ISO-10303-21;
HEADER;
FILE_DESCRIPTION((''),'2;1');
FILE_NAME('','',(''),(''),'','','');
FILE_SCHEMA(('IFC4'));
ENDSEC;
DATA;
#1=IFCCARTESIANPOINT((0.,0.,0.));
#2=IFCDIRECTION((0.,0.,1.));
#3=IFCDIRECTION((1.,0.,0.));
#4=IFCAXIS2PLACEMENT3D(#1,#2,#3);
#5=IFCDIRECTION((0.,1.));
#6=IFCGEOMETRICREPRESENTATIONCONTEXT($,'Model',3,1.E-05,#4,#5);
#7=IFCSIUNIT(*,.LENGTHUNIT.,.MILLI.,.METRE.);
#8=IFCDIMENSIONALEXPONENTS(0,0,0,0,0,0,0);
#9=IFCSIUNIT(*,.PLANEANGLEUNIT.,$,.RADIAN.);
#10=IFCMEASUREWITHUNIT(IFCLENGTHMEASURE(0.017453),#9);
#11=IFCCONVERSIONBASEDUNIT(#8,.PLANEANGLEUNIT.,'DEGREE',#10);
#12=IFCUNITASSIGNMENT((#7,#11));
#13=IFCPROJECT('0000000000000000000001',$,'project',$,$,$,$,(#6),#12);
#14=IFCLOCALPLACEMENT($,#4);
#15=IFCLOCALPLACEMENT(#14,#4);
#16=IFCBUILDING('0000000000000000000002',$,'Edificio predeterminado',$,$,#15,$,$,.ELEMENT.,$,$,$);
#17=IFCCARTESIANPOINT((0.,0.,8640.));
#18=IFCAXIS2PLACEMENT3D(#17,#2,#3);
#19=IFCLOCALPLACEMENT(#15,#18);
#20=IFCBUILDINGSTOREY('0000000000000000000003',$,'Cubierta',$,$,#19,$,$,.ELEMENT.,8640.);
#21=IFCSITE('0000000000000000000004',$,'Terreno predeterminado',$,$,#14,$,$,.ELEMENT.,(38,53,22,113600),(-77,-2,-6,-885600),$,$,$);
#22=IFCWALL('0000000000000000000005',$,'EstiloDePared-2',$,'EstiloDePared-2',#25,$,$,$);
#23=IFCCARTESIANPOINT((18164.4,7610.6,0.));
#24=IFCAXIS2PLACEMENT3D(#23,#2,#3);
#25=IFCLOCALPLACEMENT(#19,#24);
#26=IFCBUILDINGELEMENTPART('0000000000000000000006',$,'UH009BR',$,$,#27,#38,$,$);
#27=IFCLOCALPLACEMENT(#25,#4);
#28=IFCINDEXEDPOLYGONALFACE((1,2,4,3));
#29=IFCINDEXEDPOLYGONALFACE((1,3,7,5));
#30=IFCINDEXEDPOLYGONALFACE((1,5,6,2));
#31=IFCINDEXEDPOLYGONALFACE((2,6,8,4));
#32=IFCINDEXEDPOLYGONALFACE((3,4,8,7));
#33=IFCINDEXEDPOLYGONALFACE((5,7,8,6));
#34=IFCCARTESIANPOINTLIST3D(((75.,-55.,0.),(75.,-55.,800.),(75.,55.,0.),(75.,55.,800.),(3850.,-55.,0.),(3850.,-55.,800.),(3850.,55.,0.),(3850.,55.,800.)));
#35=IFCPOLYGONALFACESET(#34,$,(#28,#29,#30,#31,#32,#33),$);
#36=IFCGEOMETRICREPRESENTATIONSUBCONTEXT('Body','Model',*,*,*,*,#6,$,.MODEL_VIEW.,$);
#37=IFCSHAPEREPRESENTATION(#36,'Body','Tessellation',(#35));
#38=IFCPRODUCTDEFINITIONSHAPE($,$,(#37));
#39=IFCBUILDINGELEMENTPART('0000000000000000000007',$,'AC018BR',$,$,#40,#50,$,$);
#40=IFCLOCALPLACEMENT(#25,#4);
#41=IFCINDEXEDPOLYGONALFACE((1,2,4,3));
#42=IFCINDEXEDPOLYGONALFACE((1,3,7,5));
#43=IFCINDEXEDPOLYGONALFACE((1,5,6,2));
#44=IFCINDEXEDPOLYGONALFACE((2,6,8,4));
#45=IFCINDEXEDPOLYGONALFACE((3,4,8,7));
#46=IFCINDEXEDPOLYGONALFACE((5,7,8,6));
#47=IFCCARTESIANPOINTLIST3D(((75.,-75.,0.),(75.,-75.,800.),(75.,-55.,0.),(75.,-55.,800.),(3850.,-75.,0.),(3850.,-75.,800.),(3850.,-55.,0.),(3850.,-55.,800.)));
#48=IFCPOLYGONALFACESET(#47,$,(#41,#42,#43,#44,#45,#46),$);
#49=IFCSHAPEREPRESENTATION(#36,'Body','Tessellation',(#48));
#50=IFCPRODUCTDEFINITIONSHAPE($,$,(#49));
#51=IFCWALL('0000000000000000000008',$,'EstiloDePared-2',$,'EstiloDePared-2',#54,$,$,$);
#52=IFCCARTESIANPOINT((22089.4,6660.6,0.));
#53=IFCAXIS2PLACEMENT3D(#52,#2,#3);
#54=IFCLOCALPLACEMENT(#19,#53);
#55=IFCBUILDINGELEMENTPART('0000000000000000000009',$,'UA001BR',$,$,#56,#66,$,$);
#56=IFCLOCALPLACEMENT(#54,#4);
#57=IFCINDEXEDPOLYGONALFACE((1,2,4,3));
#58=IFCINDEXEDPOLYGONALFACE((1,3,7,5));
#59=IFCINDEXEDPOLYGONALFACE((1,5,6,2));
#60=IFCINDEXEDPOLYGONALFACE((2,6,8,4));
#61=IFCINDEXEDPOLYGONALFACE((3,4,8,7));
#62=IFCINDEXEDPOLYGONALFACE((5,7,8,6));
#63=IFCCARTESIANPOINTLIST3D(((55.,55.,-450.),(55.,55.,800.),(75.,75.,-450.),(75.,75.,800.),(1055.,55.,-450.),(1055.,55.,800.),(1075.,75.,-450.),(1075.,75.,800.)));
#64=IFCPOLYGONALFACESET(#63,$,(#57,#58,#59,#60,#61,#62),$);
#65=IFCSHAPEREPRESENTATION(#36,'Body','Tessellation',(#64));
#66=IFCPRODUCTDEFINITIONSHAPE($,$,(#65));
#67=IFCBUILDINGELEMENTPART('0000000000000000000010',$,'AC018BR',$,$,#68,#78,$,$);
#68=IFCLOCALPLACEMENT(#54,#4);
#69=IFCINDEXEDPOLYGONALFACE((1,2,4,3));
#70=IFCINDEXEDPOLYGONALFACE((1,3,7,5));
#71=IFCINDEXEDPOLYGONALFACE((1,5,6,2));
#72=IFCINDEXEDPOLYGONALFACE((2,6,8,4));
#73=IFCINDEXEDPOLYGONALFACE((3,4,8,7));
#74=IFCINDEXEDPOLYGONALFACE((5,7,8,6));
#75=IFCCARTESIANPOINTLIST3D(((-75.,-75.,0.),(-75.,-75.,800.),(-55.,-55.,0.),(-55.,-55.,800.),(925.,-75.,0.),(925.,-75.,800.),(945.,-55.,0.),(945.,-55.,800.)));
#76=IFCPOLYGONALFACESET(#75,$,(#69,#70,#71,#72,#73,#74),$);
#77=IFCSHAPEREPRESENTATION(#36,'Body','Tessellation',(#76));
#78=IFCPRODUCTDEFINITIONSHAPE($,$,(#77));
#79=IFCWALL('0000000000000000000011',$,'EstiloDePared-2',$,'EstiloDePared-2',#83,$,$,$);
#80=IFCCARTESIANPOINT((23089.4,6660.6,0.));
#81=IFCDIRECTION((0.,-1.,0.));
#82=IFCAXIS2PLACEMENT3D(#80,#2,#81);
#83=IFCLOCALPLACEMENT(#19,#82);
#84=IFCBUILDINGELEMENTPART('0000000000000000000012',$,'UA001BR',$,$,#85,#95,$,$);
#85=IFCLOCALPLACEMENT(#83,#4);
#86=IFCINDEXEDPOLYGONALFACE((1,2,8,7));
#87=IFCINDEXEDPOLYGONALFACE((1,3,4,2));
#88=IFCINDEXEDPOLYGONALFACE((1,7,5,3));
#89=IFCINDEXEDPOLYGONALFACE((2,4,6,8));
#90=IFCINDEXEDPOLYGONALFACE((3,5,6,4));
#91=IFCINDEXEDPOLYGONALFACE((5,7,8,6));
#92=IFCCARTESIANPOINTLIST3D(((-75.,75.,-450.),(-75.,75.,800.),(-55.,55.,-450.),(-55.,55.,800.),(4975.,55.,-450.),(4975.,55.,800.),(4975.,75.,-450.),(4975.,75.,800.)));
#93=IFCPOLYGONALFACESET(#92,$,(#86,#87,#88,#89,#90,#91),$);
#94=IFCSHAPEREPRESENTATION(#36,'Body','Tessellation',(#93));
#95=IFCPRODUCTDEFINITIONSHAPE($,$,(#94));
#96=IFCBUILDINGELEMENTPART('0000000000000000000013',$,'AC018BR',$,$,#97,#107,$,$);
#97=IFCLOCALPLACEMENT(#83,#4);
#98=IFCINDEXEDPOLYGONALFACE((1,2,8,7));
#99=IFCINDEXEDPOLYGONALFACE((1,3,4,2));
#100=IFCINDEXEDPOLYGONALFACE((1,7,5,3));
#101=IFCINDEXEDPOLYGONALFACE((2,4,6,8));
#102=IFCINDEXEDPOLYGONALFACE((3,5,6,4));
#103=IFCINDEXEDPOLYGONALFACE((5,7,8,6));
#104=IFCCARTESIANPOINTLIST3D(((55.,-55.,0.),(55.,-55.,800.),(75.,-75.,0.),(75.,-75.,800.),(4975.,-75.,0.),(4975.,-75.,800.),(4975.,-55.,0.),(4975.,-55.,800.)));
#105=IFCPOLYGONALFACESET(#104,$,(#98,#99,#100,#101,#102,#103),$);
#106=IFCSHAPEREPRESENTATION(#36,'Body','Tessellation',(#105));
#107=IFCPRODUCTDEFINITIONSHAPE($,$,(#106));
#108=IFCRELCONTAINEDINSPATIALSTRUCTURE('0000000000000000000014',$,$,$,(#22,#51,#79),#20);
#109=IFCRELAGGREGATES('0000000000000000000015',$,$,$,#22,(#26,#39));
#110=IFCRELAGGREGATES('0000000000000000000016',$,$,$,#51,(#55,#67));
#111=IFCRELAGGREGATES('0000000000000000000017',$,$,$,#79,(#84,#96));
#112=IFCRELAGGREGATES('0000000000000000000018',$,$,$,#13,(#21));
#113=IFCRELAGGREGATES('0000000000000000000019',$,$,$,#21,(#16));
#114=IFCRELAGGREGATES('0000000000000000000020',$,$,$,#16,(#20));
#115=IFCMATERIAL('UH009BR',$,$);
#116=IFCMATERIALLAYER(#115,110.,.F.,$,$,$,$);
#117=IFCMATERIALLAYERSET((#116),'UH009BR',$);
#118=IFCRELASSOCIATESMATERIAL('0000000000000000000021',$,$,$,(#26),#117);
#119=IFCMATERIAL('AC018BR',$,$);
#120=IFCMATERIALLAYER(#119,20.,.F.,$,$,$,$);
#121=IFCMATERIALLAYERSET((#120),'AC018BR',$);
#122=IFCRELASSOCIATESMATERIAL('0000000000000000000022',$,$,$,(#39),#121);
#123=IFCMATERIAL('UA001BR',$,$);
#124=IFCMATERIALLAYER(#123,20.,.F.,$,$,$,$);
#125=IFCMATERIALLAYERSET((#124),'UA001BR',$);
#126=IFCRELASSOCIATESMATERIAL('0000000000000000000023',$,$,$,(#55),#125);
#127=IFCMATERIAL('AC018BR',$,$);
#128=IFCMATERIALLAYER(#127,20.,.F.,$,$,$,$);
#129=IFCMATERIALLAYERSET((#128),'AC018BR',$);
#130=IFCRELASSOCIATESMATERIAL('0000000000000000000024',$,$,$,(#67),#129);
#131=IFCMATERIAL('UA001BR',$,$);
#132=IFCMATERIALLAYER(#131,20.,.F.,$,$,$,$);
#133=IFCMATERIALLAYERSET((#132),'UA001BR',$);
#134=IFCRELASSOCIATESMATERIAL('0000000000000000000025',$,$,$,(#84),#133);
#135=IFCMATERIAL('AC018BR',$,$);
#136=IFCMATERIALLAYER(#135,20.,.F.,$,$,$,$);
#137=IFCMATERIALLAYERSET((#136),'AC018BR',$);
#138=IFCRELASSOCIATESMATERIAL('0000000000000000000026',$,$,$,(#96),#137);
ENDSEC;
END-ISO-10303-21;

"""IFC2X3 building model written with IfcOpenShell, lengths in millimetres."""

from ifc_helpers import new_model, entity, si_unit, converted_unit, direction, frame, origin_with_axes, place, context, subcontext, project, spatial, polyline, outline, extrude, material, layer, layer_set, layer_usage, element, aggregate, save


model = new_model("IFC2X3")

# Units and contexts
model_context = context("Model", 3, precision=1e-05, world=origin_with_axes(), true_north=direction((0.0, 1.0)))
body_context = subcontext(model_context, "Body", "Model", "MODEL_VIEW")
ifc_project = project(units=[si_unit("LENGTHUNIT", "METRE", prefix="MILLI"), converted_unit("PLANEANGLEUNIT", "DEGREE", entity("IfcLengthMeasure", 0.017453), si_unit("PLANEANGLEUNIT", "RADIAN"), dimensions=[0, 0, 0, 0, 0, 0, 0])], contexts=[model_context])

# Site, building, storey
site_placement = place(None, origin_with_axes())
site = spatial("IfcSite", under=ifc_project, at=site_placement, Name="Terreno predeterminado", CompositionType="ELEMENT", RefLatitude=(38, 53, 22, 113600), RefLongitude=(-77, -2, -6, -885600))
building_placement = place(site_placement, origin_with_axes())
building = spatial("IfcBuilding", under=site, at=building_placement, Name="Edificio predeterminado", CompositionType="ELEMENT")
storey_placement = place(building_placement, frame((0.0, 0.0, 8640.0), z_axis=(0.0, 0.0, 1.0), x_axis=(1.0, 0.0, 0.0)))
storey = spatial("IfcBuildingStorey", under=building, at=storey_placement, Name="Cubierta", CompositionType="ELEMENT", Elevation=8640.0)

# Walls, building element parts
wall_1_placement = place(storey_placement, frame((18164.4, 7610.6, 0.0), z_axis=(0.0, 0.0, 1.0), x_axis=(1.0, 0.0, 0.0)))
wall_1 = element("IfcWall", 1, at=wall_1_placement, inside=storey, Name="EstiloDePared-2", ObjectType="EstiloDePared-2")
ifc_material_1 = material(Name="UH009BR")
ifc_layer_1 = layer(ifc_material_1, 110.0, ventilated=False)
ifc_layer_set_1 = layer_set([ifc_layer_1], Name="UH009BR")
ifc_layer_usage_1 = layer_usage(ifc_layer_set_1, "AXIS2", "NEGATIVE", -55.0)
building_element_part_1_placement = place(wall_1_placement, origin_with_axes())
building_element_part_1 = element("IfcBuildingElementPart", 2, at=building_element_part_1_placement, material=ifc_layer_usage_1, Name="UH009BR", context=body_context, shape_type="SweptSolid", body=[
    extrude(outline(polyline([(3850.0, 55.0), (3850.0, -55.0), (75.0, -55.0), (75.0, 55.0), (3850.0, 55.0)])), origin_with_axes(), (0.0, 0.0, 1.0), 800.0),
])
ifc_material_2 = material(Name="AC018BR")
ifc_layer_2 = layer(ifc_material_2, 20.0, ventilated=False)
ifc_layer_set_2 = layer_set([ifc_layer_2], Name="AC018BR")
ifc_layer_usage_2 = layer_usage(ifc_layer_set_2, "AXIS2", "NEGATIVE", 55.0)
building_element_part_2_placement = place(wall_1_placement, origin_with_axes())
building_element_part_2 = element("IfcBuildingElementPart", 3, at=building_element_part_2_placement, material=ifc_layer_usage_2, Name="AC018BR", context=body_context, shape_type="SweptSolid", body=[
    extrude(outline(polyline([(3850.0, -55.0), (3850.0, -75.0), (75.0, -75.0), (75.0, -55.0), (3850.0, -55.0)])), origin_with_axes(), (0.0, 0.0, 1.0), 800.0),
])
aggregate(wall_1, [building_element_part_1, building_element_part_2])
wall_2_placement = place(storey_placement, frame((22089.4, 6660.6, 0.0), z_axis=(0.0, 0.0, 1.0), x_axis=(1.0, 0.0, 0.0)))
wall_2 = element("IfcWall", 4, at=wall_2_placement, inside=storey, Name="EstiloDePared-2", ObjectType="EstiloDePared-2")
ifc_material_3 = material(Name="UA001BR")
ifc_layer_3 = layer(ifc_material_3, 20.0, ventilated=False)
ifc_layer_set_3 = layer_set([ifc_layer_3], Name="UA001BR")
ifc_layer_usage_3 = layer_usage(ifc_layer_set_3, "AXIS2", "NEGATIVE", -75.0)
building_element_part_3_placement = place(wall_2_placement, origin_with_axes())
building_element_part_3 = element("IfcBuildingElementPart", 5, at=building_element_part_3_placement, material=ifc_layer_usage_3, Name="UA001BR", context=body_context, shape_type="SweptSolid", body=[
    extrude(outline(polyline([(1075.0, 75.0), (1055.0, 55.0), (55.0, 55.0), (75.0, 75.0), (1075.0, 75.0)])), frame((0.0, 0.0, -450.0), z_axis=(0.0, 0.0, 1.0), x_axis=(1.0, 0.0, 0.0)), (0.0, 0.0, 1.0), 1250.0),
])
ifc_material_4 = material(Name="AC018BR")
ifc_layer_4 = layer(ifc_material_4, 20.0, ventilated=False)
ifc_layer_set_4 = layer_set([ifc_layer_4], Name="AC018BR")
ifc_layer_usage_4 = layer_usage(ifc_layer_set_4, "AXIS2", "NEGATIVE", 55.0)
building_element_part_4_placement = place(wall_2_placement, origin_with_axes())
building_element_part_4 = element("IfcBuildingElementPart", 6, at=building_element_part_4_placement, material=ifc_layer_usage_4, Name="AC018BR", context=body_context, shape_type="SweptSolid", body=[
    extrude(outline(polyline([(945.0, -55.0), (925.0, -75.0), (-75.0, -75.0), (-55.0, -55.0), (945.0, -55.0)])), origin_with_axes(), (0.0, 0.0, 1.0), 800.0),
])
aggregate(wall_2, [building_element_part_3, building_element_part_4])
wall_3_placement = place(storey_placement, frame((23089.4, 6660.6, 0.0), z_axis=(0.0, 0.0, 1.0), x_axis=(0.0, -1.0, 0.0)))
wall_3 = element("IfcWall", 7, at=wall_3_placement, inside=storey, Name="EstiloDePared-2", ObjectType="EstiloDePared-2")
ifc_material_5 = material(Name="UA001BR")
ifc_layer_5 = layer(ifc_material_5, 20.0, ventilated=False)
ifc_layer_set_5 = layer_set([ifc_layer_5], Name="UA001BR")
ifc_layer_usage_5 = layer_usage(ifc_layer_set_5, "AXIS2", "NEGATIVE", -75.0)
building_element_part_5_placement = place(wall_3_placement, origin_with_axes())
building_element_part_5 = element("IfcBuildingElementPart", 8, at=building_element_part_5_placement, material=ifc_layer_usage_5, Name="UA001BR", context=body_context, shape_type="SweptSolid", body=[
    extrude(outline(polyline([(4975.0, 75.0), (4975.0, 55.0), (-55.0, 55.0), (-75.0, 75.0), (4975.0, 75.0)])), frame((0.0, 0.0, -450.0), z_axis=(0.0, 0.0, 1.0), x_axis=(1.0, 0.0, 0.0)), (0.0, 0.0, 1.0), 1250.0),
])
ifc_material_6 = material(Name="AC018BR")
ifc_layer_6 = layer(ifc_material_6, 20.0, ventilated=False)
ifc_layer_set_6 = layer_set([ifc_layer_6], Name="AC018BR")
ifc_layer_usage_6 = layer_usage(ifc_layer_set_6, "AXIS2", "NEGATIVE", 55.0)
building_element_part_6_placement = place(wall_3_placement, origin_with_axes())
building_element_part_6 = element("IfcBuildingElementPart", 9, at=building_element_part_6_placement, material=ifc_layer_usage_6, Name="AC018BR", context=body_context, shape_type="SweptSolid", body=[
    extrude(outline(polyline([(4975.0, -55.0), (4975.0, -75.0), (75.0, -75.0), (55.0, -55.0), (4975.0, -55.0)])), origin_with_axes(), (0.0, 0.0, 1.0), 800.0),
])
aggregate(wall_3, [building_element_part_5, building_element_part_6])

save(model, "model.ifc")
